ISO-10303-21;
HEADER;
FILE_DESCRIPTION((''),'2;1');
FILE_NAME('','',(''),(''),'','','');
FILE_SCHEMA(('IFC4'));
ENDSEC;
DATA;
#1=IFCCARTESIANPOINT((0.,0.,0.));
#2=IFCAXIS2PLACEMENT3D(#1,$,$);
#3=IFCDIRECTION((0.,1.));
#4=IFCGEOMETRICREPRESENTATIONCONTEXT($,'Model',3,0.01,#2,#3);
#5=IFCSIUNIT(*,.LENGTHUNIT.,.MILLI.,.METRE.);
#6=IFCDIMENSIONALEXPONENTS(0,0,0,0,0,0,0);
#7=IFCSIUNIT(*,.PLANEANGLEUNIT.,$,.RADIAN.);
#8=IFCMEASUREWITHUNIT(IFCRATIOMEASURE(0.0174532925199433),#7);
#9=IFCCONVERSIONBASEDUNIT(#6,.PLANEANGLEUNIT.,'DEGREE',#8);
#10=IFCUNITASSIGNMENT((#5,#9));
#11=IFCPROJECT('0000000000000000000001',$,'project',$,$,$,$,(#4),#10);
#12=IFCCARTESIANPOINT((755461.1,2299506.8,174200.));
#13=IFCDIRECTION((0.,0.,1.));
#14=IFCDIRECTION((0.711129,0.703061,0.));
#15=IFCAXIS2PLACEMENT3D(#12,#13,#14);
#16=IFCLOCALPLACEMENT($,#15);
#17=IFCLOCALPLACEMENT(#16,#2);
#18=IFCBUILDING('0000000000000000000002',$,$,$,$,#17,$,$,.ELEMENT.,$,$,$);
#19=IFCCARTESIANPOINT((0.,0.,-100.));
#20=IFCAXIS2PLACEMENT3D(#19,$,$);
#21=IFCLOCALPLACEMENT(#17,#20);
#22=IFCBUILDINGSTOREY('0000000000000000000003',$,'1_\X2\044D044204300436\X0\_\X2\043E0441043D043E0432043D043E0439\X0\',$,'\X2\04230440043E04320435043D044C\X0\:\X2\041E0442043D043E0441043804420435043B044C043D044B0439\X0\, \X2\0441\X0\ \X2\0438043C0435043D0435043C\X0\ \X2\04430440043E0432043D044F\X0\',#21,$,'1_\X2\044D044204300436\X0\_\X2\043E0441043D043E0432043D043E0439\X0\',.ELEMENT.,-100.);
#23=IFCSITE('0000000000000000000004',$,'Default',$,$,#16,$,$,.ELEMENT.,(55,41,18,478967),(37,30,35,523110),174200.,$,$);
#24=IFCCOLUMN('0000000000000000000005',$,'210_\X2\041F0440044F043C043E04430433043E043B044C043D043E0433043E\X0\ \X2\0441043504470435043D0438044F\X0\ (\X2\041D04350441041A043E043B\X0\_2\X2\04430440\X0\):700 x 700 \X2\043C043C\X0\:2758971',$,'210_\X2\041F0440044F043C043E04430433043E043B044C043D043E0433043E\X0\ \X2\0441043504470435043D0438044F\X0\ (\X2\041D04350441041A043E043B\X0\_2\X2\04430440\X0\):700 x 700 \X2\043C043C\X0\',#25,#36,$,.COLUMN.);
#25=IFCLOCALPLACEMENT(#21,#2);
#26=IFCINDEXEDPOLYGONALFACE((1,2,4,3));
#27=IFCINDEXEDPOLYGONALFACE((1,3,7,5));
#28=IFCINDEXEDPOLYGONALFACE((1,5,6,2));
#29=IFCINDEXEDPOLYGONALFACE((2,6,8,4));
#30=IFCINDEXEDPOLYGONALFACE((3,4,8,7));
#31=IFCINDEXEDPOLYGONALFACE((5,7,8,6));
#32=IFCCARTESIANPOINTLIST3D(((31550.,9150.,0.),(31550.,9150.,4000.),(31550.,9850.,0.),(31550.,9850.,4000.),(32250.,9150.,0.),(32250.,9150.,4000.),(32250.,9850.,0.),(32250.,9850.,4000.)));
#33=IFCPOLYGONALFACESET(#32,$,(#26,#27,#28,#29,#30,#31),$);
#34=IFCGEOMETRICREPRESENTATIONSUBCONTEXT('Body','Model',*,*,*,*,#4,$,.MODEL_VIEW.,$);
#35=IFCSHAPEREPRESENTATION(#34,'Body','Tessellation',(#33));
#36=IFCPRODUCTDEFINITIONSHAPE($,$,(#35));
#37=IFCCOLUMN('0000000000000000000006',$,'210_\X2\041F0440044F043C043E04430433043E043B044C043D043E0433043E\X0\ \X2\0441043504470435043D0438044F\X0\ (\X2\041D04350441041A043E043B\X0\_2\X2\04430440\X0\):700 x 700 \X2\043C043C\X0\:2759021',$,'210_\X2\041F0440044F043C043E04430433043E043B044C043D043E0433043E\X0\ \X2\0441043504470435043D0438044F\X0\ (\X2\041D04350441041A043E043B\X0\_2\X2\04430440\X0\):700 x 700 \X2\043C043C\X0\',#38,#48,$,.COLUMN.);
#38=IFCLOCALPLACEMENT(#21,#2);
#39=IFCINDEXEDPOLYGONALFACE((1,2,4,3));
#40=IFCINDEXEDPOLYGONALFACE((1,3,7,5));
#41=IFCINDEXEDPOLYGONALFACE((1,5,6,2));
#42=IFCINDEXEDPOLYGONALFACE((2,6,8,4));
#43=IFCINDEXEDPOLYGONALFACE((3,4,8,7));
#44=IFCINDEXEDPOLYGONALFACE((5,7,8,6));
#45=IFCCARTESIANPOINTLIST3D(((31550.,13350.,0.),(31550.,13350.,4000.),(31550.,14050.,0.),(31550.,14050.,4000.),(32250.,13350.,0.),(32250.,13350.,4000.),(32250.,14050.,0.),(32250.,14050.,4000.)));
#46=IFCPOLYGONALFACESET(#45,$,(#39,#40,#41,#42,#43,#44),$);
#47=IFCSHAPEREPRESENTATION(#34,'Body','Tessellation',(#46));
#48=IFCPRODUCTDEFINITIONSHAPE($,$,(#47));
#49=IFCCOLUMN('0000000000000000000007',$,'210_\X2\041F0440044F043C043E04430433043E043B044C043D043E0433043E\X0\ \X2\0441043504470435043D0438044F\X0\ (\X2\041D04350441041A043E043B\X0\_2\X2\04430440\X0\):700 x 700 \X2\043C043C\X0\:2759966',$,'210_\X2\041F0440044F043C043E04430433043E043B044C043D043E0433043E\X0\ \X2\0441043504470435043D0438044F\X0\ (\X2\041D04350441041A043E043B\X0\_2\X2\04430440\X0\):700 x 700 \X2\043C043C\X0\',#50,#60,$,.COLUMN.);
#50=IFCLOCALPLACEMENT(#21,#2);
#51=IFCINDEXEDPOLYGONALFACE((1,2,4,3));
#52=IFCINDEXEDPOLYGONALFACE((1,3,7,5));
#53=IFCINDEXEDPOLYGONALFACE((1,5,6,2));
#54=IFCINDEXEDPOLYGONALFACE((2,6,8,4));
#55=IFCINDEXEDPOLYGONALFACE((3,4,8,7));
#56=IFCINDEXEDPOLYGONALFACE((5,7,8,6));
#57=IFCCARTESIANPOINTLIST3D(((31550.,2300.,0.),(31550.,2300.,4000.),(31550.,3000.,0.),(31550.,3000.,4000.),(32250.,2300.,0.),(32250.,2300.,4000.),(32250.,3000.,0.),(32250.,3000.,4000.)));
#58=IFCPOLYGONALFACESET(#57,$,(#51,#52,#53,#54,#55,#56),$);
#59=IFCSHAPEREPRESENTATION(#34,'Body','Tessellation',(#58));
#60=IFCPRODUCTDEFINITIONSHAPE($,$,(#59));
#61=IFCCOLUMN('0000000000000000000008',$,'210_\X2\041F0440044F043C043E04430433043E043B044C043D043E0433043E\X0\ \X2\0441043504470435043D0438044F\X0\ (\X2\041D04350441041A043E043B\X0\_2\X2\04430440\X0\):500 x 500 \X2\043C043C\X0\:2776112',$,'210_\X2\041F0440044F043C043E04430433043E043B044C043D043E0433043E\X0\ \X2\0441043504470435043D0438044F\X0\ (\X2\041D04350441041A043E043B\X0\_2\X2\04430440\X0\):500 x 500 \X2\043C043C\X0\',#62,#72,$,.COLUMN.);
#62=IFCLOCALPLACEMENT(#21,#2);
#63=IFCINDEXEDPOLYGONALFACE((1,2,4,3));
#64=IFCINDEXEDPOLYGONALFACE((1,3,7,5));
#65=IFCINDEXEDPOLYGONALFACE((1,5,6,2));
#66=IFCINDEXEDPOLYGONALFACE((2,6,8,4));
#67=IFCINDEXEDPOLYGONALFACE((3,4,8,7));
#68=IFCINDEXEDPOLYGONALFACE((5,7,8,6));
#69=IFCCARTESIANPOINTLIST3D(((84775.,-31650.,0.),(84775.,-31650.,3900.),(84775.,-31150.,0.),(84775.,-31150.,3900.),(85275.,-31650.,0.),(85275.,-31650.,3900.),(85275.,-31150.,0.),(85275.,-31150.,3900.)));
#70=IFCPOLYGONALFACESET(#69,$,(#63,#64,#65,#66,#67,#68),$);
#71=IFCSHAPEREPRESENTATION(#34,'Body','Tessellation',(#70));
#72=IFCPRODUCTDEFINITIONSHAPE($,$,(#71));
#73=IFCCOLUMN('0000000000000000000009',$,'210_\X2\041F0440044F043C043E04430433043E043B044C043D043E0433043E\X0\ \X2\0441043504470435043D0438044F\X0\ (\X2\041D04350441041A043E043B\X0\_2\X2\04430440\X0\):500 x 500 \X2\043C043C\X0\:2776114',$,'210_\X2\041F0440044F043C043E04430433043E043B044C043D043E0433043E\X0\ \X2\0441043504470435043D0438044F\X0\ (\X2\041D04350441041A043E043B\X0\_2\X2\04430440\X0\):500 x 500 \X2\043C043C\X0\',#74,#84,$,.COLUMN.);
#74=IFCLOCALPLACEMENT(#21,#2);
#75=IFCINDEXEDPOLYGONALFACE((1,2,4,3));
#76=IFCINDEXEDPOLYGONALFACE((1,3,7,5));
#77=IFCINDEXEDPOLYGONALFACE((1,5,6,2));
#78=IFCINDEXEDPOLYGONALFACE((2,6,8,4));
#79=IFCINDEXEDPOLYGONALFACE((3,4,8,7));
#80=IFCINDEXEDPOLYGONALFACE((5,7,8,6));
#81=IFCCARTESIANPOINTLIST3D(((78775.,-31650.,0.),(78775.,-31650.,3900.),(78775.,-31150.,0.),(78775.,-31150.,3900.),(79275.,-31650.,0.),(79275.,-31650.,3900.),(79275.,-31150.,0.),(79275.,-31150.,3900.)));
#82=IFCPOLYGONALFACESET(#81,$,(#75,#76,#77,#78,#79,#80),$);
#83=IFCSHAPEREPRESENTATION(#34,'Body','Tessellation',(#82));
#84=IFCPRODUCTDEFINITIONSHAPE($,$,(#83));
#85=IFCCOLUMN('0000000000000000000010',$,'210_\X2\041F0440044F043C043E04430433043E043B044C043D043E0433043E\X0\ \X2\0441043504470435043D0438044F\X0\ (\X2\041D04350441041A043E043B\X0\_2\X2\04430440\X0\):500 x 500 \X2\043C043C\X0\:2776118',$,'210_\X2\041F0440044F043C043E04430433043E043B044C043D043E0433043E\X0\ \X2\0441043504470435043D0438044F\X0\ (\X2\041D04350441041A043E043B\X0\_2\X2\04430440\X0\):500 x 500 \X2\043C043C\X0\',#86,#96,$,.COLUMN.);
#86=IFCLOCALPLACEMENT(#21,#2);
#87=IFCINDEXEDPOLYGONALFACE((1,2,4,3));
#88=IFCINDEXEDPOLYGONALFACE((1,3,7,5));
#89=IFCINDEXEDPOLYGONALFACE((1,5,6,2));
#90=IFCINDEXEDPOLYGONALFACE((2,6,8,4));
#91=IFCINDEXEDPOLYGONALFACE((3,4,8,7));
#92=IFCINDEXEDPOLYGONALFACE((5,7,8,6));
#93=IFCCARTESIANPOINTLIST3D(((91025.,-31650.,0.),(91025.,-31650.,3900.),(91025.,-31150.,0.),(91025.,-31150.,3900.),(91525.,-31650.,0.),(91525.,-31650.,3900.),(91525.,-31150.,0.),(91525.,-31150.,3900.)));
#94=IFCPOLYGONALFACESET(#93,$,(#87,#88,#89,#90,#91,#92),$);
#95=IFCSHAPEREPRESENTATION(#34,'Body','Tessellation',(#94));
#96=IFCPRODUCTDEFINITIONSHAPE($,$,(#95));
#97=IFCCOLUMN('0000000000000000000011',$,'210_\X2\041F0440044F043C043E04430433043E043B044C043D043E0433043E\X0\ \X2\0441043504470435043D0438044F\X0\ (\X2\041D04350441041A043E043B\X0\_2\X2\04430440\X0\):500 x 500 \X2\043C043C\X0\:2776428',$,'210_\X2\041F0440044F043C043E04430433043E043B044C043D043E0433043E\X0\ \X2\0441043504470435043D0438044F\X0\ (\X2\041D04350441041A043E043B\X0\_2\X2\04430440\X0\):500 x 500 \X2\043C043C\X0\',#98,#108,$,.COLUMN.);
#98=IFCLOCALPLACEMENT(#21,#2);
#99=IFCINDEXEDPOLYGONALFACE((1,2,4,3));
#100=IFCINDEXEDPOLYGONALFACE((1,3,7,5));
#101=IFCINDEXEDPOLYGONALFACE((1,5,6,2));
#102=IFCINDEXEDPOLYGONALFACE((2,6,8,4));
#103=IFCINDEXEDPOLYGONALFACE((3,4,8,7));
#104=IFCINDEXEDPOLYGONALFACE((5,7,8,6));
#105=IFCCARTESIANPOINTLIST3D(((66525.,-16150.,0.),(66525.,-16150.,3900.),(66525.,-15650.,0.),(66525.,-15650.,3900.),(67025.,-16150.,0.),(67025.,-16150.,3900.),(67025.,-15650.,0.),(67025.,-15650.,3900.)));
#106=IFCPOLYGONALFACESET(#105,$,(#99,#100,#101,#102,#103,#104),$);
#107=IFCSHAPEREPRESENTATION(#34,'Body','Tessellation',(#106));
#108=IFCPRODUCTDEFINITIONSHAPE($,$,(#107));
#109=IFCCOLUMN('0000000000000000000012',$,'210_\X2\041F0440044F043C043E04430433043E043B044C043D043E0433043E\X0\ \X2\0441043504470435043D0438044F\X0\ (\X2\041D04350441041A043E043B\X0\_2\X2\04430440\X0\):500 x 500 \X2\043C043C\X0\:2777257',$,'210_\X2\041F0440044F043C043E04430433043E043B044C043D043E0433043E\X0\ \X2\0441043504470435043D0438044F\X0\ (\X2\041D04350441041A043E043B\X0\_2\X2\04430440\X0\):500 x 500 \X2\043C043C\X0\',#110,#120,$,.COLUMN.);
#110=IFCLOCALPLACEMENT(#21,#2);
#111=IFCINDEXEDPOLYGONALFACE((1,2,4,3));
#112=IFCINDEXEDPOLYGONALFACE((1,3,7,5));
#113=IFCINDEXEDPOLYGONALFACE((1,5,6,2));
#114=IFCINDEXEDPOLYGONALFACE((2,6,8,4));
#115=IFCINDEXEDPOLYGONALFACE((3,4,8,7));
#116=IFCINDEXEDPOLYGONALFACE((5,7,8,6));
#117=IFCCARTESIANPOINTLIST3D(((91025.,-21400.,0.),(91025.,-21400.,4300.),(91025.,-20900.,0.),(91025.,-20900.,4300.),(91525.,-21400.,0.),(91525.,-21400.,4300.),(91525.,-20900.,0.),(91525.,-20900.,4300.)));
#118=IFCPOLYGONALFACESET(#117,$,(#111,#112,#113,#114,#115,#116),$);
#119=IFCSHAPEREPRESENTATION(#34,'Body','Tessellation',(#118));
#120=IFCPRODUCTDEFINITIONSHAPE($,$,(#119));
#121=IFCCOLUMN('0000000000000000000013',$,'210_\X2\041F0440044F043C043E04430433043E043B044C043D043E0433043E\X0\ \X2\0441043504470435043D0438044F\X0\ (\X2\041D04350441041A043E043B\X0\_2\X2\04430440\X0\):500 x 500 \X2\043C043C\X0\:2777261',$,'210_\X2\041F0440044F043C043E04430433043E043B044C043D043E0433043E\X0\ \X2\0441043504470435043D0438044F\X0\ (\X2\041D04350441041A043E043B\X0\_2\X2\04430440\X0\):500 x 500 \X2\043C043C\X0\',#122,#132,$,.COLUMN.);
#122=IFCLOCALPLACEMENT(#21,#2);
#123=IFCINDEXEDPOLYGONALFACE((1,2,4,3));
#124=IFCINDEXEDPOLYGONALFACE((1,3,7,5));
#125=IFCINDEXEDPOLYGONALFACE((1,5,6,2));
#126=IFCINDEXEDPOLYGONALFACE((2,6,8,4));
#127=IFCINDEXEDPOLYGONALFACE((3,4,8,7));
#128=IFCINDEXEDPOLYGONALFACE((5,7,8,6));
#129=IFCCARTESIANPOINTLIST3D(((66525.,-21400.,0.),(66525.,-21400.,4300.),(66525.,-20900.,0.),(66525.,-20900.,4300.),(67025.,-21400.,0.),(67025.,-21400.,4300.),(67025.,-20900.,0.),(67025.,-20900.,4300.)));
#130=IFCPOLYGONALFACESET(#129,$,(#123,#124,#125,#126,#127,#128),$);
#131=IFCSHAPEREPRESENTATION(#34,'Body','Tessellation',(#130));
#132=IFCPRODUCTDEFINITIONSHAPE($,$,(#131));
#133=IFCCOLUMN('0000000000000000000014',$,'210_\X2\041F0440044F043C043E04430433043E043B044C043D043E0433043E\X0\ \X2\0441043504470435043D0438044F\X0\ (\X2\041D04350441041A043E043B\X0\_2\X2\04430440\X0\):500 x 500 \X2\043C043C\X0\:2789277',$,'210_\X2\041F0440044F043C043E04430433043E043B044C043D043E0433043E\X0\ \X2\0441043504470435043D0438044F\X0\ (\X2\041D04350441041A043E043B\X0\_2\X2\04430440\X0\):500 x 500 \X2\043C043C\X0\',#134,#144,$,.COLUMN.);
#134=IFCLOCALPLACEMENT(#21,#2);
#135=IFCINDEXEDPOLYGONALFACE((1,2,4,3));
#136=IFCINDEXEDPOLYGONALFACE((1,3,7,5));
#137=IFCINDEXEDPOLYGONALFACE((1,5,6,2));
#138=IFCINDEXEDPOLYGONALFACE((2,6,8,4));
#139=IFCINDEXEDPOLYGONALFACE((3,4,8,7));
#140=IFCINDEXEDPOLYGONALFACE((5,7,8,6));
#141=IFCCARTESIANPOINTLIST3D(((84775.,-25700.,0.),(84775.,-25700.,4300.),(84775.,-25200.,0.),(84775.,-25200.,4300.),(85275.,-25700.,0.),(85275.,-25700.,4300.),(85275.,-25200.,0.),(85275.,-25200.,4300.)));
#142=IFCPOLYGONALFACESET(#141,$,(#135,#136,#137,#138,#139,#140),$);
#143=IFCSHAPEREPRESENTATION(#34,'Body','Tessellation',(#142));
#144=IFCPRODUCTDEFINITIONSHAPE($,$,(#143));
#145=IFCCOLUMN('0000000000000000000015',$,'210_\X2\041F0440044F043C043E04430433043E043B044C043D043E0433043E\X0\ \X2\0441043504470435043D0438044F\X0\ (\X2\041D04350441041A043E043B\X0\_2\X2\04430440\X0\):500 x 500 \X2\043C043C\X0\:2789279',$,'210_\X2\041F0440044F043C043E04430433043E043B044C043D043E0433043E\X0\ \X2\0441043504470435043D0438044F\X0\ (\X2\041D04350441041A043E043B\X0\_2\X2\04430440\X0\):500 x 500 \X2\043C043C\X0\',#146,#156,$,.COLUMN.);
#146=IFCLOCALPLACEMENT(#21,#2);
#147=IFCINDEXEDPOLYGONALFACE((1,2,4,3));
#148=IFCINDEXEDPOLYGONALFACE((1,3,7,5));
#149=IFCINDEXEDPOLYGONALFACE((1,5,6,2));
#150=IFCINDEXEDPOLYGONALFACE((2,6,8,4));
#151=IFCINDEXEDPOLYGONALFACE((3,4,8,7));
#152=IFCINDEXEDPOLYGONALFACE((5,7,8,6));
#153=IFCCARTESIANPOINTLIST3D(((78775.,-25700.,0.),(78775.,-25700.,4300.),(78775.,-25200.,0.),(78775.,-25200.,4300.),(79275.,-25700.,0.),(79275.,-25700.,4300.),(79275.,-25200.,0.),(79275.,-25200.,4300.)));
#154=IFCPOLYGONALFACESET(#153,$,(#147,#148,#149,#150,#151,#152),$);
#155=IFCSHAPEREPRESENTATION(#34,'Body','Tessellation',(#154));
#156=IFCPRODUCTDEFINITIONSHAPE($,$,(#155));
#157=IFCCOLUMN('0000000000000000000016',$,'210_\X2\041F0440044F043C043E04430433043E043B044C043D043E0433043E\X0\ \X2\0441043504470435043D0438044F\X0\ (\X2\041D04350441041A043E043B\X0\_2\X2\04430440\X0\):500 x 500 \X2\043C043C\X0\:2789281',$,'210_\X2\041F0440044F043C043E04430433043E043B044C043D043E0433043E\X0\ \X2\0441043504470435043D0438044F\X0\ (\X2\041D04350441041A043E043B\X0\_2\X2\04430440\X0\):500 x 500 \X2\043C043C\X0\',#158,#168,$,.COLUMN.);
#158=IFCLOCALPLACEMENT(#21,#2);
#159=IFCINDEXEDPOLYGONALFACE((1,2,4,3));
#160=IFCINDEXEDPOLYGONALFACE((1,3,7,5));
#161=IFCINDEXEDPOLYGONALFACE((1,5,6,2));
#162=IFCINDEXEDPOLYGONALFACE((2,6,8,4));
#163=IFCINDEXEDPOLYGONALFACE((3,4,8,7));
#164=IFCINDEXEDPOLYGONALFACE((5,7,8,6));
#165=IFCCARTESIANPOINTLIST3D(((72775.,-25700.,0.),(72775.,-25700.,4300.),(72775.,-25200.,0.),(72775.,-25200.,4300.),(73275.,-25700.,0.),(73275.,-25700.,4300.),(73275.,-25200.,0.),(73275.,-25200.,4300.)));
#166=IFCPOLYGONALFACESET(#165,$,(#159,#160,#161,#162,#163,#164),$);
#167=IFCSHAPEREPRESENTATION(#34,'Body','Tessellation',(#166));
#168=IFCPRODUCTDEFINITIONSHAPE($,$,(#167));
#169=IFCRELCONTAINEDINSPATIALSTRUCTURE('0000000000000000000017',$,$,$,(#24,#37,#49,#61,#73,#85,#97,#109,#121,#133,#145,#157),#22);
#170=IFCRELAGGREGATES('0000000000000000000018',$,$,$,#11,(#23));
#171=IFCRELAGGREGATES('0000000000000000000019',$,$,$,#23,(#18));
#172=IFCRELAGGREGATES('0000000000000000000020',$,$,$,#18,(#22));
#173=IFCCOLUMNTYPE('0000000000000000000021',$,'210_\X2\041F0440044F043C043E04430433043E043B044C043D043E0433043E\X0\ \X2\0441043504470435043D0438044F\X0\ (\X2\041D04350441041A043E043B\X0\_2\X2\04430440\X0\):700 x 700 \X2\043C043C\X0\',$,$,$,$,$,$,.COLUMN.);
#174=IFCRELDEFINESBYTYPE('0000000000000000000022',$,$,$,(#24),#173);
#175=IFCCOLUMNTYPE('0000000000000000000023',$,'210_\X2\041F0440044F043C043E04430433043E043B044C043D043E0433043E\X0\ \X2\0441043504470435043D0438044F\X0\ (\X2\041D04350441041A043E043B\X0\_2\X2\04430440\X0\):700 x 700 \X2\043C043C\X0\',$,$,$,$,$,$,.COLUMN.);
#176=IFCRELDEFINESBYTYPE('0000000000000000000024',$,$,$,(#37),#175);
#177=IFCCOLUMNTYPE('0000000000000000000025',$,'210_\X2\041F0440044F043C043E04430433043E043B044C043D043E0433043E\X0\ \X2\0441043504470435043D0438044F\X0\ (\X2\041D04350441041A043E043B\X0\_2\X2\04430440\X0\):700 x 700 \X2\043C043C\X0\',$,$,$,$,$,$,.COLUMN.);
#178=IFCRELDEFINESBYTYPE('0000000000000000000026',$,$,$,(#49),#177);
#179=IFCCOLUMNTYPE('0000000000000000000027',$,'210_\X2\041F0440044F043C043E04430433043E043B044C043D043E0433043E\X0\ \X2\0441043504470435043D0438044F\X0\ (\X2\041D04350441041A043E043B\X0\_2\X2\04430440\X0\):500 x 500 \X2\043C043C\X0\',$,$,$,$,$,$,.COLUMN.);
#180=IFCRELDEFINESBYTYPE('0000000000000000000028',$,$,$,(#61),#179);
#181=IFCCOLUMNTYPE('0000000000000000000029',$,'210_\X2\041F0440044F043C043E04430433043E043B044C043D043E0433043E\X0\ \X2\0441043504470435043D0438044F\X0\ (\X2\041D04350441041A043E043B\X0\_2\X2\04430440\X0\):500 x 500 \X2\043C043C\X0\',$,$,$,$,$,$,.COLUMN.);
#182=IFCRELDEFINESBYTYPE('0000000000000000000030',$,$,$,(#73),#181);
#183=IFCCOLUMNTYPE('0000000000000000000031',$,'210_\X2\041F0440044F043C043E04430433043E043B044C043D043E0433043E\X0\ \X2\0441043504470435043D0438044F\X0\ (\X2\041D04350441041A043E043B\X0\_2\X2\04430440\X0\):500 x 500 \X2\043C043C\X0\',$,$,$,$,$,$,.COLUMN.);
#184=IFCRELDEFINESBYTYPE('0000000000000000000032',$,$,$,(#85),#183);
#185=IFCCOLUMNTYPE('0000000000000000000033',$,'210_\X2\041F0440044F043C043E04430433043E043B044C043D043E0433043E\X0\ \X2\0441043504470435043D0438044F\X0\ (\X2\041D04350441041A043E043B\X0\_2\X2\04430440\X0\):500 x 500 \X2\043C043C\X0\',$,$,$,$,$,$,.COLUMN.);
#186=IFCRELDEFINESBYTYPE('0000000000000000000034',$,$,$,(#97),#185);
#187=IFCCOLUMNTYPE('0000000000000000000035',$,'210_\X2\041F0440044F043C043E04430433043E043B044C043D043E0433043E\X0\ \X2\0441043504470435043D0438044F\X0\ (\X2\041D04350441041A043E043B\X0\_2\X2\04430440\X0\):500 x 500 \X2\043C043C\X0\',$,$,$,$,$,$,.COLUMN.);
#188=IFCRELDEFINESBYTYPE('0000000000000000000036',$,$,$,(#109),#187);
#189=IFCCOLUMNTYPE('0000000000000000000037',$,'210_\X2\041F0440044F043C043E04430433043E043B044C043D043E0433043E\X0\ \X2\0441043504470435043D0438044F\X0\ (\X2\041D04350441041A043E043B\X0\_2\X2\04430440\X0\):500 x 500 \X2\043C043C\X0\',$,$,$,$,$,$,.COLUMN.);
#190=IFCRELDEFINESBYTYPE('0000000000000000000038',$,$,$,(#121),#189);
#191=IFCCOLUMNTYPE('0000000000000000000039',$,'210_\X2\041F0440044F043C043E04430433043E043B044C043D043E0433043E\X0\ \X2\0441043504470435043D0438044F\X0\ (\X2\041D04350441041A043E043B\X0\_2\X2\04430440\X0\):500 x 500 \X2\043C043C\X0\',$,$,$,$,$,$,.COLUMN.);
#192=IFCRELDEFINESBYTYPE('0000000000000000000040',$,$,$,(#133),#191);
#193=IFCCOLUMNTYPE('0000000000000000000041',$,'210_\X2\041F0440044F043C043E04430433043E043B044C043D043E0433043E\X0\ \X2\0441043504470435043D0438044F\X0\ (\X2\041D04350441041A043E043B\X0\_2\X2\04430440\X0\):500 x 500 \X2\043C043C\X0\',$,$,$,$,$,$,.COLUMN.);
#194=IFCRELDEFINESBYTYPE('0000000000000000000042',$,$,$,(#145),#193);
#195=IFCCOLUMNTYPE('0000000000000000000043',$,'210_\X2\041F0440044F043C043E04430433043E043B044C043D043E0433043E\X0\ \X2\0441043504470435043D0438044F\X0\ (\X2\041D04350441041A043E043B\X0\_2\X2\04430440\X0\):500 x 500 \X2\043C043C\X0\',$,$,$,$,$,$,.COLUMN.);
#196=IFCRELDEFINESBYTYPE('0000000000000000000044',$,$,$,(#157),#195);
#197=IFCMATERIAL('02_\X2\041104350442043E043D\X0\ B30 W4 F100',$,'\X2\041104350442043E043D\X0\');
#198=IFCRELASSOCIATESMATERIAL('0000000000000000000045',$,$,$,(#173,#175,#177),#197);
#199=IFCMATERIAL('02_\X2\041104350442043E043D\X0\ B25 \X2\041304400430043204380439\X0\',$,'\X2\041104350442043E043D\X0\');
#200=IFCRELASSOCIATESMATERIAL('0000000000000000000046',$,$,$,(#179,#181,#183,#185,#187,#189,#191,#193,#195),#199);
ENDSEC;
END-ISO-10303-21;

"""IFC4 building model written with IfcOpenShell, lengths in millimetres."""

from ifc_helpers import new_model, entity, si_unit, converted_unit, direction, frame, origin, place, context, subcontext, project, spatial, indexed_curve, outline, extrude, source, transform, mapped, material, type_object, type_shapes, element, save


model = new_model("IFC4")

# Units and contexts
model_context = context("Model", 3, precision=0.01, world=origin(), true_north=direction((0.0, 1.0)))
body_context = subcontext(model_context, "Body", "Model", "MODEL_VIEW")
ifc_project = project(units=[si_unit("LENGTHUNIT", "METRE", prefix="MILLI"), converted_unit("PLANEANGLEUNIT", "DEGREE", entity("IfcRatioMeasure", 0.0174532925199433), si_unit("PLANEANGLEUNIT", "RADIAN"), dimensions=[0, 0, 0, 0, 0, 0, 0])], contexts=[model_context])

# Site, building, storey
site_placement = place(None, frame((755461.1, 2299506.8, 174200.0), z_axis=(0.0, 0.0, 1.0), x_axis=(0.711129, 0.703061, 0.0)))
site = spatial("IfcSite", under=ifc_project, at=site_placement, Name="Default", CompositionType="ELEMENT", RefLatitude=(55, 41, 18, 478967), RefLongitude=(37, 30, 35, 523110), RefElevation=174200.0)
building_placement = place(site_placement, origin())
building = spatial("IfcBuilding", under=site, at=building_placement, CompositionType="ELEMENT")
storey_placement = place(building_placement, frame((0.0, 0.0, -100.0)))
storey = spatial("IfcBuildingStorey", under=building, at=storey_placement, Name="1_этаж_основной", ObjectType="Уровень:Относительный, с именем уровня", LongName="1_этаж_основной", CompositionType="ELEMENT", Elevation=-100.0)

# Columns
ifc_material_1 = material(Name="02_Бетон B25 Гравий", Category="Бетон")
ifc_material_2 = material(Name="02_Бетон B30 W4 F100", Category="Бетон")
column_type_1 = type_object("IfcColumnType", Name="210_Прямоугольного сечения (НесКол_2ур):700 x 700 мм", PredefinedType="COLUMN", material=ifc_material_2)
shared_shape_1 = source(origin(), body_context, "Body", "SweptSolid", [
    extrude(outline(indexed_curve([(-350.0, -350.0), (350.0, -350.0), (350.0, 350.0), (-350.0, 350.0), (-350.0, -350.0)], self_intersect=False)), frame((31900.0, 9500.0, -100.0), z_axis=(0.0, 0.0, 1.0), x_axis=(0.0, -1.0, 0.0)), (0.0, 0.0, 1.0), 4000.0),
])
type_shapes(column_type_1, [shared_shape_1])
column_1_placement = place(storey_placement, frame((0.0, 0.0, 100.0)))
element("IfcColumn", 1, at=column_1_placement, inside=storey, type_object=column_type_1, Name="210_Прямоугольного сечения (НесКол_2ур):700 x 700 мм:2758971", ObjectType="210_Прямоугольного сечения (НесКол_2ур):700 x 700 мм", PredefinedType="COLUMN", context=body_context, shape_type="MappedRepresentation", body=[
    mapped(shared_shape_1, transform((0.0, 0.0, 0.0), scale=1.0)),
])
column_type_2 = type_object("IfcColumnType", Name="210_Прямоугольного сечения (НесКол_2ур):700 x 700 мм", PredefinedType="COLUMN", material=ifc_material_2)
shared_shape_2 = source(origin(), body_context, "Body", "SweptSolid", [
    extrude(outline(indexed_curve([(-350.0, -350.0), (350.0, -350.0), (350.0, 350.0), (-350.0, 350.0), (-350.0, -350.0)], self_intersect=False)), frame((31900.0, 13700.0, -100.0), z_axis=(0.0, 0.0, 1.0), x_axis=(0.0, -1.0, 0.0)), (0.0, 0.0, 1.0), 4000.0),
])
type_shapes(column_type_2, [shared_shape_2])
column_2_placement = place(storey_placement, frame((0.0, 0.0, 100.0)))
element("IfcColumn", 2, at=column_2_placement, inside=storey, type_object=column_type_2, Name="210_Прямоугольного сечения (НесКол_2ур):700 x 700 мм:2759021", ObjectType="210_Прямоугольного сечения (НесКол_2ур):700 x 700 мм", PredefinedType="COLUMN", context=body_context, shape_type="MappedRepresentation", body=[
    mapped(shared_shape_2, transform((0.0, 0.0, 0.0), scale=1.0)),
])
column_type_3 = type_object("IfcColumnType", Name="210_Прямоугольного сечения (НесКол_2ур):700 x 700 мм", PredefinedType="COLUMN", material=ifc_material_2)
shared_shape_3 = source(origin(), body_context, "Body", "SweptSolid", [
    extrude(outline(indexed_curve([(-350.0, -350.0), (350.0, -350.0), (350.0, 350.0), (-350.0, 350.0), (-350.0, -350.0)], self_intersect=False)), frame((31900.0, 2650.0, -100.0), z_axis=(0.0, 0.0, 1.0), x_axis=(0.0, -1.0, 0.0)), (0.0, 0.0, 1.0), 4000.0),
])
type_shapes(column_type_3, [shared_shape_3])
column_3_placement = place(storey_placement, frame((0.0, 0.0, 100.0)))
element("IfcColumn", 3, at=column_3_placement, inside=storey, type_object=column_type_3, Name="210_Прямоугольного сечения (НесКол_2ур):700 x 700 мм:2759966", ObjectType="210_Прямоугольного сечения (НесКол_2ур):700 x 700 мм", PredefinedType="COLUMN", context=body_context, shape_type="MappedRepresentation", body=[
    mapped(shared_shape_3, transform((0.0, 0.0, 0.0), scale=1.0)),
])
column_type_4 = type_object("IfcColumnType", Name="210_Прямоугольного сечения (НесКол_2ур):500 x 500 мм", PredefinedType="COLUMN", material=ifc_material_1)
shared_shape_4 = source(origin(), body_context, "Body", "SweptSolid", [
    extrude(outline(indexed_curve([(-250.0, -250.0), (250.0, -250.0), (250.0, 250.0), (-250.0, 250.0), (-250.0, -250.0)], self_intersect=False)), frame((85025.0, -31400.0, -100.0), z_axis=(0.0, 0.0, 1.0), x_axis=(0.0, -1.0, 0.0)), (0.0, 0.0, 1.0), 3900.0),
])
type_shapes(column_type_4, [shared_shape_4])
column_4_placement = place(storey_placement, frame((0.0, 0.0, 100.0)))
element("IfcColumn", 4, at=column_4_placement, inside=storey, type_object=column_type_4, Name="210_Прямоугольного сечения (НесКол_2ур):500 x 500 мм:2776112", ObjectType="210_Прямоугольного сечения (НесКол_2ур):500 x 500 мм", PredefinedType="COLUMN", context=body_context, shape_type="MappedRepresentation", body=[
    mapped(shared_shape_4, transform((0.0, 0.0, 0.0), scale=1.0)),
])
column_type_5 = type_object("IfcColumnType", Name="210_Прямоугольного сечения (НесКол_2ур):500 x 500 мм", PredefinedType="COLUMN", material=ifc_material_1)
shared_shape_5 = source(origin(), body_context, "Body", "SweptSolid", [
    extrude(outline(indexed_curve([(-250.0, -250.0), (250.0, -250.0), (250.0, 250.0), (-250.0, 250.0), (-250.0, -250.0)], self_intersect=False)), frame((79025.0, -31400.0, -100.0), z_axis=(0.0, 0.0, 1.0), x_axis=(0.0, -1.0, 0.0)), (0.0, 0.0, 1.0), 3900.0),
])
type_shapes(column_type_5, [shared_shape_5])
column_5_placement = place(storey_placement, frame((0.0, 0.0, 100.0)))
element("IfcColumn", 5, at=column_5_placement, inside=storey, type_object=column_type_5, Name="210_Прямоугольного сечения (НесКол_2ур):500 x 500 мм:2776114", ObjectType="210_Прямоугольного сечения (НесКол_2ур):500 x 500 мм", PredefinedType="COLUMN", context=body_context, shape_type="MappedRepresentation", body=[
    mapped(shared_shape_5, transform((0.0, 0.0, 0.0), scale=1.0)),
])
column_type_6 = type_object("IfcColumnType", Name="210_Прямоугольного сечения (НесКол_2ур):500 x 500 мм", PredefinedType="COLUMN", material=ifc_material_1)
shared_shape_6 = source(origin(), body_context, "Body", "SweptSolid", [
    extrude(outline(indexed_curve([(-250.0, -250.0), (250.0, -250.0), (250.0, 250.0), (-250.0, 250.0), (-250.0, -250.0)], self_intersect=False)), frame((91275.0, -31400.0, -100.0), z_axis=(0.0, 0.0, 1.0), x_axis=(0.0, -1.0, 0.0)), (0.0, 0.0, 1.0), 3900.0),
])
type_shapes(column_type_6, [shared_shape_6])
column_6_placement = place(storey_placement, frame((0.0, 0.0, 100.0)))
element("IfcColumn", 6, at=column_6_placement, inside=storey, type_object=column_type_6, Name="210_Прямоугольного сечения (НесКол_2ур):500 x 500 мм:2776118", ObjectType="210_Прямоугольного сечения (НесКол_2ур):500 x 500 мм", PredefinedType="COLUMN", context=body_context, shape_type="MappedRepresentation", body=[
    mapped(shared_shape_6, transform((0.0, 0.0, 0.0), scale=1.0)),
])
column_type_7 = type_object("IfcColumnType", Name="210_Прямоугольного сечения (НесКол_2ур):500 x 500 мм", PredefinedType="COLUMN", material=ifc_material_1)
shared_shape_7 = source(origin(), body_context, "Body", "SweptSolid", [
    extrude(outline(indexed_curve([(-250.0, -250.0), (250.0, -250.0), (250.0, 250.0), (-250.0, 250.0), (-250.0, -250.0)], self_intersect=False)), frame((66775.0, -15900.0, -100.0), z_axis=(0.0, 0.0, 1.0), x_axis=(0.0, -1.0, 0.0)), (0.0, 0.0, 1.0), 3900.0),
])
type_shapes(column_type_7, [shared_shape_7])
column_7_placement = place(storey_placement, frame((0.0, 0.0, 100.0)))
element("IfcColumn", 7, at=column_7_placement, inside=storey, type_object=column_type_7, Name="210_Прямоугольного сечения (НесКол_2ур):500 x 500 мм:2776428", ObjectType="210_Прямоугольного сечения (НесКол_2ур):500 x 500 мм", PredefinedType="COLUMN", context=body_context, shape_type="MappedRepresentation", body=[
    mapped(shared_shape_7, transform((0.0, 0.0, 0.0), scale=1.0)),
])
column_type_8 = type_object("IfcColumnType", Name="210_Прямоугольного сечения (НесКол_2ур):500 x 500 мм", PredefinedType="COLUMN", material=ifc_material_1)
shared_shape_8 = source(origin(), body_context, "Body", "SweptSolid", [
    extrude(outline(indexed_curve([(-250.0, -250.0), (250.0, -250.0), (250.0, 250.0), (-250.0, 250.0), (-250.0, -250.0)], self_intersect=False)), frame((91275.0, -21150.0, -100.0), z_axis=(0.0, 0.0, 1.0), x_axis=(0.0, -1.0, 0.0)), (0.0, 0.0, 1.0), 4300.0),
])
type_shapes(column_type_8, [shared_shape_8])
column_8_placement = place(storey_placement, frame((0.0, 0.0, 100.0)))
element("IfcColumn", 8, at=column_8_placement, inside=storey, type_object=column_type_8, Name="210_Прямоугольного сечения (НесКол_2ур):500 x 500 мм:2777257", ObjectType="210_Прямоугольного сечения (НесКол_2ур):500 x 500 мм", PredefinedType="COLUMN", context=body_context, shape_type="MappedRepresentation", body=[
    mapped(shared_shape_8, transform((0.0, 0.0, 0.0), scale=1.0)),
])
column_type_9 = type_object("IfcColumnType", Name="210_Прямоугольного сечения (НесКол_2ур):500 x 500 мм", PredefinedType="COLUMN", material=ifc_material_1)
shared_shape_9 = source(origin(), body_context, "Body", "SweptSolid", [
    extrude(outline(indexed_curve([(-250.0, -250.0), (250.0, -250.0), (250.0, 250.0), (-250.0, 250.0), (-250.0, -250.0)], self_intersect=False)), frame((66775.0, -21150.0, -100.0), z_axis=(0.0, 0.0, 1.0), x_axis=(0.0, -1.0, 0.0)), (0.0, 0.0, 1.0), 4300.0),
])
type_shapes(column_type_9, [shared_shape_9])
column_9_placement = place(storey_placement, frame((0.0, 0.0, 100.0)))
element("IfcColumn", 9, at=column_9_placement, inside=storey, type_object=column_type_9, Name="210_Прямоугольного сечения (НесКол_2ур):500 x 500 мм:2777261", ObjectType="210_Прямоугольного сечения (НесКол_2ур):500 x 500 мм", PredefinedType="COLUMN", context=body_context, shape_type="MappedRepresentation", body=[
    mapped(shared_shape_9, transform((0.0, 0.0, 0.0), scale=1.0)),
])
column_type_10 = type_object("IfcColumnType", Name="210_Прямоугольного сечения (НесКол_2ур):500 x 500 мм", PredefinedType="COLUMN", material=ifc_material_1)
shared_shape_10 = source(origin(), body_context, "Body", "SweptSolid", [
    extrude(outline(indexed_curve([(-250.0, -250.0), (250.0, -250.0), (250.0, 250.0), (-250.0, 250.0), (-250.0, -250.0)], self_intersect=False)), frame((85025.0, -25450.0, -100.0), z_axis=(0.0, 0.0, 1.0), x_axis=(0.0, -1.0, 0.0)), (0.0, 0.0, 1.0), 4300.0),
])
type_shapes(column_type_10, [shared_shape_10])
column_10_placement = place(storey_placement, frame((0.0, 0.0, 100.0)))
element("IfcColumn", 10, at=column_10_placement, inside=storey, type_object=column_type_10, Name="210_Прямоугольного сечения (НесКол_2ур):500 x 500 мм:2789277", ObjectType="210_Прямоугольного сечения (НесКол_2ур):500 x 500 мм", PredefinedType="COLUMN", context=body_context, shape_type="MappedRepresentation", body=[
    mapped(shared_shape_10, transform((0.0, 0.0, 0.0), scale=1.0)),
])
column_type_11 = type_object("IfcColumnType", Name="210_Прямоугольного сечения (НесКол_2ур):500 x 500 мм", PredefinedType="COLUMN", material=ifc_material_1)
shared_shape_11 = source(origin(), body_context, "Body", "SweptSolid", [
    extrude(outline(indexed_curve([(-250.0, -250.0), (250.0, -250.0), (250.0, 250.0), (-250.0, 250.0), (-250.0, -250.0)], self_intersect=False)), frame((79025.0, -25450.0, -100.0), z_axis=(0.0, 0.0, 1.0), x_axis=(0.0, -1.0, 0.0)), (0.0, 0.0, 1.0), 4300.0),
])
type_shapes(column_type_11, [shared_shape_11])
column_11_placement = place(storey_placement, frame((0.0, 0.0, 100.0)))
element("IfcColumn", 11, at=column_11_placement, inside=storey, type_object=column_type_11, Name="210_Прямоугольного сечения (НесКол_2ур):500 x 500 мм:2789279", ObjectType="210_Прямоугольного сечения (НесКол_2ур):500 x 500 мм", PredefinedType="COLUMN", context=body_context, shape_type="MappedRepresentation", body=[
    mapped(shared_shape_11, transform((0.0, 0.0, 0.0), scale=1.0)),
])
column_type_12 = type_object("IfcColumnType", Name="210_Прямоугольного сечения (НесКол_2ур):500 x 500 мм", PredefinedType="COLUMN", material=ifc_material_1)
shared_shape_12 = source(origin(), body_context, "Body", "SweptSolid", [
    extrude(outline(indexed_curve([(-250.0, -250.0), (250.0, -250.0), (250.0, 250.0), (-250.0, 250.0), (-250.0, -250.0)], self_intersect=False)), frame((73025.0, -25450.0, -100.0), z_axis=(0.0, 0.0, 1.0), x_axis=(0.0, -1.0, 0.0)), (0.0, 0.0, 1.0), 4300.0),
])
type_shapes(column_type_12, [shared_shape_12])
column_12_placement = place(storey_placement, frame((0.0, 0.0, 100.0)))
element("IfcColumn", 12, at=column_12_placement, inside=storey, type_object=column_type_12, Name="210_Прямоугольного сечения (НесКол_2ур):500 x 500 мм:2789281", ObjectType="210_Прямоугольного сечения (НесКол_2ур):500 x 500 мм", PredefinedType="COLUMN", context=body_context, shape_type="MappedRepresentation", body=[
    mapped(shared_shape_12, transform((0.0, 0.0, 0.0), scale=1.0)),
])

save(model, "model.ifc")
